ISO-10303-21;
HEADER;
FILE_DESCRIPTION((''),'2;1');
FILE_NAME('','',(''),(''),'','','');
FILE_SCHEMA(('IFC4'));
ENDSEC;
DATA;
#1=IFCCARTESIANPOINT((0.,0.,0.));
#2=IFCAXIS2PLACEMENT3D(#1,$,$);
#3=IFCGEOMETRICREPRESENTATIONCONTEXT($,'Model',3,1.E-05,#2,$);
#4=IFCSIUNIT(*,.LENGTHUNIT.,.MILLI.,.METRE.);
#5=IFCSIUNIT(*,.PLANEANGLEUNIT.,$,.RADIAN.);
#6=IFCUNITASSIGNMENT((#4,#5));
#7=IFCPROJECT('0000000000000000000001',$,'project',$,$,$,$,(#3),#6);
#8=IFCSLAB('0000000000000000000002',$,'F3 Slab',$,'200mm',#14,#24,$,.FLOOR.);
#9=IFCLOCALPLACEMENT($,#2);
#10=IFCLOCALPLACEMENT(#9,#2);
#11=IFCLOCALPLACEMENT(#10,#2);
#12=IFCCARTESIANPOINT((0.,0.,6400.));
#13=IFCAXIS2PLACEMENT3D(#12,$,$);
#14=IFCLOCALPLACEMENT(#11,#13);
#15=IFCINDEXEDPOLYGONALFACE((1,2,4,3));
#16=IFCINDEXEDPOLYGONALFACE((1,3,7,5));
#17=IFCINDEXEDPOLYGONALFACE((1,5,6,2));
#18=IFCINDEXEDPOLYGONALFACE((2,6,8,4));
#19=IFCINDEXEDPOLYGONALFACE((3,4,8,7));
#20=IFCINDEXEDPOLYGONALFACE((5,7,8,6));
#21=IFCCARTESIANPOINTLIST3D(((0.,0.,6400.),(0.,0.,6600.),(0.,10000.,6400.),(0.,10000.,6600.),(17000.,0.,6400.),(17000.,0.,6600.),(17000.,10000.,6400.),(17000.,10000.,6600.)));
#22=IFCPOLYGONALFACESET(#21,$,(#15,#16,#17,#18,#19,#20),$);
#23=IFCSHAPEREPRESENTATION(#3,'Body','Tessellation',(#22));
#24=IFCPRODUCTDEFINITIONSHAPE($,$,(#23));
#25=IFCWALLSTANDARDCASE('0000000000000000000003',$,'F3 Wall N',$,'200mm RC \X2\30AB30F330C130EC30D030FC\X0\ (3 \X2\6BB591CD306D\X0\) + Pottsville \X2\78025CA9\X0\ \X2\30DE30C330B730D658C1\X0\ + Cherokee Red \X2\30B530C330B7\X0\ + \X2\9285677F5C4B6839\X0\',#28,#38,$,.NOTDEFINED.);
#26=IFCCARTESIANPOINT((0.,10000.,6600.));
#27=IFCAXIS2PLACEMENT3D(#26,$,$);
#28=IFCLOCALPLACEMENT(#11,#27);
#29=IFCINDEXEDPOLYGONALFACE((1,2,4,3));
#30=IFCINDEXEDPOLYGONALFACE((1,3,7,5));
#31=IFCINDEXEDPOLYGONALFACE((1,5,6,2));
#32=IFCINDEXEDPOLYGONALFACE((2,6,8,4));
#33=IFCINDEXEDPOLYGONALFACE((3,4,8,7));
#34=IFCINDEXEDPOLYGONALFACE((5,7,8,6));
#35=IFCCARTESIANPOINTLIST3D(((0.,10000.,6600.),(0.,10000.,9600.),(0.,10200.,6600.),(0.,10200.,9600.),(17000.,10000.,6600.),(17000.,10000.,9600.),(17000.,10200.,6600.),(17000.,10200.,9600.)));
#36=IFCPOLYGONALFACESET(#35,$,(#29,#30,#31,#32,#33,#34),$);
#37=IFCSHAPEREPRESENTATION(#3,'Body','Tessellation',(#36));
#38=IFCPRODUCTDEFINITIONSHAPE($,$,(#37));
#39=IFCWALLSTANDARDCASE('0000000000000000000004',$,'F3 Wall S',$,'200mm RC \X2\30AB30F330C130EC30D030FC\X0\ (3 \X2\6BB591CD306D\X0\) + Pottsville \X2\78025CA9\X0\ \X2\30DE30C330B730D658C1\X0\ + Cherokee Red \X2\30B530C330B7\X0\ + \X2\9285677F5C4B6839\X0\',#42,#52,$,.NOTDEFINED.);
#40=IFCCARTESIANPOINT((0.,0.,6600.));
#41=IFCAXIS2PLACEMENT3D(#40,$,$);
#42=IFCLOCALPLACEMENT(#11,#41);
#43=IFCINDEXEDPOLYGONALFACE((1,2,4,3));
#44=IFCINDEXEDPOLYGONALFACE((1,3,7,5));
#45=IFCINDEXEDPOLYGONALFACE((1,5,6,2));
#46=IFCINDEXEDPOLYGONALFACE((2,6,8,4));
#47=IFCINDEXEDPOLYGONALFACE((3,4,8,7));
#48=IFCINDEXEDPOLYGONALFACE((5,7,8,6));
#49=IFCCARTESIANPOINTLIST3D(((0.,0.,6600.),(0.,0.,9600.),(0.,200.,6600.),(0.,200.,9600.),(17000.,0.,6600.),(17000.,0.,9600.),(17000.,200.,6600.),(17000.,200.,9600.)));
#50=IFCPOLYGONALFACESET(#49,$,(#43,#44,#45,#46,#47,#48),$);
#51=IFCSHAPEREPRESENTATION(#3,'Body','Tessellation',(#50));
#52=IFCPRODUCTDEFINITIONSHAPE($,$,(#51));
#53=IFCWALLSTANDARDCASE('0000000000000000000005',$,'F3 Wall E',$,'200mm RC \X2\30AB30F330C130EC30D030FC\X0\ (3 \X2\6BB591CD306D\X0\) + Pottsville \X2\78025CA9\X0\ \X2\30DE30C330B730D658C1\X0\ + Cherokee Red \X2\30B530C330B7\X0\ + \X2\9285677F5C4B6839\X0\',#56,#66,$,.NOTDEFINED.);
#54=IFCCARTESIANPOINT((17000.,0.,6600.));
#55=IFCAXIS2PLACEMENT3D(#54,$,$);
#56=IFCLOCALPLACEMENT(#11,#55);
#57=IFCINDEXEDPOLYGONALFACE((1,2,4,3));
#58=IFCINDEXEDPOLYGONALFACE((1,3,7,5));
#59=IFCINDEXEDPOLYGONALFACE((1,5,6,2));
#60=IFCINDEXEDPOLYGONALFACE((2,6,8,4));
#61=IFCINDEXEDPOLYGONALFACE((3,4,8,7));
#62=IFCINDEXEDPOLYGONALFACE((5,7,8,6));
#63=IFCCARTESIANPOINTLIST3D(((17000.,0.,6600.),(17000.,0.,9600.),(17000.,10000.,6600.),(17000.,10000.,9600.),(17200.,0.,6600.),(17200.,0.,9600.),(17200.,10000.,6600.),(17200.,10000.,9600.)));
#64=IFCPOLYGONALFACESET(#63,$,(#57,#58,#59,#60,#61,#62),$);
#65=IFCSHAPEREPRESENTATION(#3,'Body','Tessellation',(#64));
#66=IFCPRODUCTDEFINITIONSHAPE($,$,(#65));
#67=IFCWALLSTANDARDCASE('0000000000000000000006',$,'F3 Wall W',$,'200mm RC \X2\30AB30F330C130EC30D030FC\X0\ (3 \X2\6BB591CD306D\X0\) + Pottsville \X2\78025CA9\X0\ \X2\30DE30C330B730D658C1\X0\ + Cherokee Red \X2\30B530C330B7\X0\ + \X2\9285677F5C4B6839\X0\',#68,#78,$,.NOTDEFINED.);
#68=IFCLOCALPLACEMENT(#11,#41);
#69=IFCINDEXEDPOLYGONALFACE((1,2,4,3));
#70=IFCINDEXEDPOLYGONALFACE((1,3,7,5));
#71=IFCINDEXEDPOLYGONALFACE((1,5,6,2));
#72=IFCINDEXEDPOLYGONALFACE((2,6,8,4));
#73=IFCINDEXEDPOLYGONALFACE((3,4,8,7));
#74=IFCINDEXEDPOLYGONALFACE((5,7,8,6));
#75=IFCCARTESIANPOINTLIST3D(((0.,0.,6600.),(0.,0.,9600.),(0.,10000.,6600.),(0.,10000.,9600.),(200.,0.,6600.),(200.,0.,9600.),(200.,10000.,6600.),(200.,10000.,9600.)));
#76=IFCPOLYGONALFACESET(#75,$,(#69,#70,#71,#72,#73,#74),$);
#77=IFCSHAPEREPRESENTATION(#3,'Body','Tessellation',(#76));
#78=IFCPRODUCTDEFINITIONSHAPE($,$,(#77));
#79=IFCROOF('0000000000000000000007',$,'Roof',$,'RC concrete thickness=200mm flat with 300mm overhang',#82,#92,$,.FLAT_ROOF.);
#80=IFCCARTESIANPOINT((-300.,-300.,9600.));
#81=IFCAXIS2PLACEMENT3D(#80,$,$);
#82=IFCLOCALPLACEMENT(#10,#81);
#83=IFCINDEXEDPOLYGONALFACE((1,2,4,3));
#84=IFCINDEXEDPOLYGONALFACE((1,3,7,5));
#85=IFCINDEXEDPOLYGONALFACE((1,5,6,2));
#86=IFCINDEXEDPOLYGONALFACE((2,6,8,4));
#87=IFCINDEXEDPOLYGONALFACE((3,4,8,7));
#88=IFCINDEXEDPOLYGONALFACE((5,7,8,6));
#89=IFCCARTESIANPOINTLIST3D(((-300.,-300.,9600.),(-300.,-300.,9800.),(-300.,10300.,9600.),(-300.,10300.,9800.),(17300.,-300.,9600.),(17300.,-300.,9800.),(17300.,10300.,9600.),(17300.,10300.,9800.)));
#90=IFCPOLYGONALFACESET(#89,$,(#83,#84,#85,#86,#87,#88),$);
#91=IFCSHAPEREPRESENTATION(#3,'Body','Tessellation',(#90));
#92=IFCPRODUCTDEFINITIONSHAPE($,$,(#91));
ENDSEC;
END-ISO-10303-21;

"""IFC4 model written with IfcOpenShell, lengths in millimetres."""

from ifc_helpers import new_model, si_unit, frame, frame_2d, origin, place, context, project, rectangle, extrude, element, save


model = new_model("IFC4")

# Units and contexts
model_context = context("Model", 3, precision=1e-05, world=origin())
ifc_project = project(units=[si_unit("LENGTHUNIT", "METRE", prefix="MILLI"), si_unit("PLANEANGLEUNIT", "RADIAN")], contexts=[model_context])

# Slab
placement_1 = place(None, origin())
placement_2 = place(placement_1, origin())
placement_3 = place(placement_2, origin())
slab_placement = place(placement_3, frame((0.0, 0.0, 6400.0)))
element("IfcSlab", 1, at=slab_placement, Name="F3 Slab", ObjectType="200mm", PredefinedType="FLOOR", context=model_context, shape_type="SweptSolid", body=[
    extrude(rectangle(XDim=17000.0, YDim=10000.0, at=frame_2d((8500.0, 5000.0))), frame((0.0, 0.0, 6400.0)), (0.0, 0.0, 1.0), 200.0),
])

# Walls
wall_1_placement = place(placement_3, frame((0.0, 10000.0, 6600.0)))
element("IfcWallStandardCase", 2, at=wall_1_placement, Name="F3 Wall N", ObjectType="200mm RC カンチレバー (3 段重ね) + Pottsville 砂岩 マッシブ壁 + Cherokee Red サッシ + 銅板屋根", PredefinedType="NOTDEFINED", context=model_context, shape_type="SweptSolid", body=[
    extrude(rectangle(XDim=17000.0, YDim=200.0, at=frame_2d((8500.0, 100.0))), frame((0.0, 10000.0, 6600.0)), (0.0, 0.0, 1.0), 3000.0),
])
wall_2_placement = place(placement_3, frame((0.0, 0.0, 6600.0)))
element("IfcWallStandardCase", 3, at=wall_2_placement, Name="F3 Wall S", ObjectType="200mm RC カンチレバー (3 段重ね) + Pottsville 砂岩 マッシブ壁 + Cherokee Red サッシ + 銅板屋根", PredefinedType="NOTDEFINED", context=model_context, shape_type="SweptSolid", body=[
    extrude(rectangle(XDim=17000.0, YDim=200.0, at=frame_2d((8500.0, 100.0))), frame((0.0, 0.0, 6600.0)), (0.0, 0.0, 1.0), 3000.0),
])
wall_3_placement = place(placement_3, frame((17000.0, 0.0, 6600.0)))
element("IfcWallStandardCase", 4, at=wall_3_placement, Name="F3 Wall E", ObjectType="200mm RC カンチレバー (3 段重ね) + Pottsville 砂岩 マッシブ壁 + Cherokee Red サッシ + 銅板屋根", PredefinedType="NOTDEFINED", context=model_context, shape_type="SweptSolid", body=[
    extrude(rectangle(XDim=200.0, YDim=10000.0, at=frame_2d((100.0, 5000.0))), frame((17000.0, 0.0, 6600.0)), (0.0, 0.0, 1.0), 3000.0),
])
wall_4_placement = place(placement_3, frame((0.0, 0.0, 6600.0)))
element("IfcWallStandardCase", 5, at=wall_4_placement, Name="F3 Wall W", ObjectType="200mm RC カンチレバー (3 段重ね) + Pottsville 砂岩 マッシブ壁 + Cherokee Red サッシ + 銅板屋根", PredefinedType="NOTDEFINED", context=model_context, shape_type="SweptSolid", body=[
    extrude(rectangle(XDim=200.0, YDim=10000.0, at=frame_2d((100.0, 5000.0))), frame((0.0, 0.0, 6600.0)), (0.0, 0.0, 1.0), 3000.0),
])

# Roof
roof_placement = place(placement_2, frame((-300.0, -300.0, 9600.0)))
element("IfcRoof", 6, at=roof_placement, Name="Roof", ObjectType="RC concrete thickness=200mm flat with 300mm overhang", PredefinedType="FLAT_ROOF", context=model_context, shape_type="SweptSolid", body=[
    extrude(rectangle(XDim=17600.0, YDim=10600.0, at=frame_2d((8800.0, 5300.0))), frame((-300.0, -300.0, 9600.0)), (0.0, 0.0, 1.0), 200.0),
])

save(model, "model.ifc")
